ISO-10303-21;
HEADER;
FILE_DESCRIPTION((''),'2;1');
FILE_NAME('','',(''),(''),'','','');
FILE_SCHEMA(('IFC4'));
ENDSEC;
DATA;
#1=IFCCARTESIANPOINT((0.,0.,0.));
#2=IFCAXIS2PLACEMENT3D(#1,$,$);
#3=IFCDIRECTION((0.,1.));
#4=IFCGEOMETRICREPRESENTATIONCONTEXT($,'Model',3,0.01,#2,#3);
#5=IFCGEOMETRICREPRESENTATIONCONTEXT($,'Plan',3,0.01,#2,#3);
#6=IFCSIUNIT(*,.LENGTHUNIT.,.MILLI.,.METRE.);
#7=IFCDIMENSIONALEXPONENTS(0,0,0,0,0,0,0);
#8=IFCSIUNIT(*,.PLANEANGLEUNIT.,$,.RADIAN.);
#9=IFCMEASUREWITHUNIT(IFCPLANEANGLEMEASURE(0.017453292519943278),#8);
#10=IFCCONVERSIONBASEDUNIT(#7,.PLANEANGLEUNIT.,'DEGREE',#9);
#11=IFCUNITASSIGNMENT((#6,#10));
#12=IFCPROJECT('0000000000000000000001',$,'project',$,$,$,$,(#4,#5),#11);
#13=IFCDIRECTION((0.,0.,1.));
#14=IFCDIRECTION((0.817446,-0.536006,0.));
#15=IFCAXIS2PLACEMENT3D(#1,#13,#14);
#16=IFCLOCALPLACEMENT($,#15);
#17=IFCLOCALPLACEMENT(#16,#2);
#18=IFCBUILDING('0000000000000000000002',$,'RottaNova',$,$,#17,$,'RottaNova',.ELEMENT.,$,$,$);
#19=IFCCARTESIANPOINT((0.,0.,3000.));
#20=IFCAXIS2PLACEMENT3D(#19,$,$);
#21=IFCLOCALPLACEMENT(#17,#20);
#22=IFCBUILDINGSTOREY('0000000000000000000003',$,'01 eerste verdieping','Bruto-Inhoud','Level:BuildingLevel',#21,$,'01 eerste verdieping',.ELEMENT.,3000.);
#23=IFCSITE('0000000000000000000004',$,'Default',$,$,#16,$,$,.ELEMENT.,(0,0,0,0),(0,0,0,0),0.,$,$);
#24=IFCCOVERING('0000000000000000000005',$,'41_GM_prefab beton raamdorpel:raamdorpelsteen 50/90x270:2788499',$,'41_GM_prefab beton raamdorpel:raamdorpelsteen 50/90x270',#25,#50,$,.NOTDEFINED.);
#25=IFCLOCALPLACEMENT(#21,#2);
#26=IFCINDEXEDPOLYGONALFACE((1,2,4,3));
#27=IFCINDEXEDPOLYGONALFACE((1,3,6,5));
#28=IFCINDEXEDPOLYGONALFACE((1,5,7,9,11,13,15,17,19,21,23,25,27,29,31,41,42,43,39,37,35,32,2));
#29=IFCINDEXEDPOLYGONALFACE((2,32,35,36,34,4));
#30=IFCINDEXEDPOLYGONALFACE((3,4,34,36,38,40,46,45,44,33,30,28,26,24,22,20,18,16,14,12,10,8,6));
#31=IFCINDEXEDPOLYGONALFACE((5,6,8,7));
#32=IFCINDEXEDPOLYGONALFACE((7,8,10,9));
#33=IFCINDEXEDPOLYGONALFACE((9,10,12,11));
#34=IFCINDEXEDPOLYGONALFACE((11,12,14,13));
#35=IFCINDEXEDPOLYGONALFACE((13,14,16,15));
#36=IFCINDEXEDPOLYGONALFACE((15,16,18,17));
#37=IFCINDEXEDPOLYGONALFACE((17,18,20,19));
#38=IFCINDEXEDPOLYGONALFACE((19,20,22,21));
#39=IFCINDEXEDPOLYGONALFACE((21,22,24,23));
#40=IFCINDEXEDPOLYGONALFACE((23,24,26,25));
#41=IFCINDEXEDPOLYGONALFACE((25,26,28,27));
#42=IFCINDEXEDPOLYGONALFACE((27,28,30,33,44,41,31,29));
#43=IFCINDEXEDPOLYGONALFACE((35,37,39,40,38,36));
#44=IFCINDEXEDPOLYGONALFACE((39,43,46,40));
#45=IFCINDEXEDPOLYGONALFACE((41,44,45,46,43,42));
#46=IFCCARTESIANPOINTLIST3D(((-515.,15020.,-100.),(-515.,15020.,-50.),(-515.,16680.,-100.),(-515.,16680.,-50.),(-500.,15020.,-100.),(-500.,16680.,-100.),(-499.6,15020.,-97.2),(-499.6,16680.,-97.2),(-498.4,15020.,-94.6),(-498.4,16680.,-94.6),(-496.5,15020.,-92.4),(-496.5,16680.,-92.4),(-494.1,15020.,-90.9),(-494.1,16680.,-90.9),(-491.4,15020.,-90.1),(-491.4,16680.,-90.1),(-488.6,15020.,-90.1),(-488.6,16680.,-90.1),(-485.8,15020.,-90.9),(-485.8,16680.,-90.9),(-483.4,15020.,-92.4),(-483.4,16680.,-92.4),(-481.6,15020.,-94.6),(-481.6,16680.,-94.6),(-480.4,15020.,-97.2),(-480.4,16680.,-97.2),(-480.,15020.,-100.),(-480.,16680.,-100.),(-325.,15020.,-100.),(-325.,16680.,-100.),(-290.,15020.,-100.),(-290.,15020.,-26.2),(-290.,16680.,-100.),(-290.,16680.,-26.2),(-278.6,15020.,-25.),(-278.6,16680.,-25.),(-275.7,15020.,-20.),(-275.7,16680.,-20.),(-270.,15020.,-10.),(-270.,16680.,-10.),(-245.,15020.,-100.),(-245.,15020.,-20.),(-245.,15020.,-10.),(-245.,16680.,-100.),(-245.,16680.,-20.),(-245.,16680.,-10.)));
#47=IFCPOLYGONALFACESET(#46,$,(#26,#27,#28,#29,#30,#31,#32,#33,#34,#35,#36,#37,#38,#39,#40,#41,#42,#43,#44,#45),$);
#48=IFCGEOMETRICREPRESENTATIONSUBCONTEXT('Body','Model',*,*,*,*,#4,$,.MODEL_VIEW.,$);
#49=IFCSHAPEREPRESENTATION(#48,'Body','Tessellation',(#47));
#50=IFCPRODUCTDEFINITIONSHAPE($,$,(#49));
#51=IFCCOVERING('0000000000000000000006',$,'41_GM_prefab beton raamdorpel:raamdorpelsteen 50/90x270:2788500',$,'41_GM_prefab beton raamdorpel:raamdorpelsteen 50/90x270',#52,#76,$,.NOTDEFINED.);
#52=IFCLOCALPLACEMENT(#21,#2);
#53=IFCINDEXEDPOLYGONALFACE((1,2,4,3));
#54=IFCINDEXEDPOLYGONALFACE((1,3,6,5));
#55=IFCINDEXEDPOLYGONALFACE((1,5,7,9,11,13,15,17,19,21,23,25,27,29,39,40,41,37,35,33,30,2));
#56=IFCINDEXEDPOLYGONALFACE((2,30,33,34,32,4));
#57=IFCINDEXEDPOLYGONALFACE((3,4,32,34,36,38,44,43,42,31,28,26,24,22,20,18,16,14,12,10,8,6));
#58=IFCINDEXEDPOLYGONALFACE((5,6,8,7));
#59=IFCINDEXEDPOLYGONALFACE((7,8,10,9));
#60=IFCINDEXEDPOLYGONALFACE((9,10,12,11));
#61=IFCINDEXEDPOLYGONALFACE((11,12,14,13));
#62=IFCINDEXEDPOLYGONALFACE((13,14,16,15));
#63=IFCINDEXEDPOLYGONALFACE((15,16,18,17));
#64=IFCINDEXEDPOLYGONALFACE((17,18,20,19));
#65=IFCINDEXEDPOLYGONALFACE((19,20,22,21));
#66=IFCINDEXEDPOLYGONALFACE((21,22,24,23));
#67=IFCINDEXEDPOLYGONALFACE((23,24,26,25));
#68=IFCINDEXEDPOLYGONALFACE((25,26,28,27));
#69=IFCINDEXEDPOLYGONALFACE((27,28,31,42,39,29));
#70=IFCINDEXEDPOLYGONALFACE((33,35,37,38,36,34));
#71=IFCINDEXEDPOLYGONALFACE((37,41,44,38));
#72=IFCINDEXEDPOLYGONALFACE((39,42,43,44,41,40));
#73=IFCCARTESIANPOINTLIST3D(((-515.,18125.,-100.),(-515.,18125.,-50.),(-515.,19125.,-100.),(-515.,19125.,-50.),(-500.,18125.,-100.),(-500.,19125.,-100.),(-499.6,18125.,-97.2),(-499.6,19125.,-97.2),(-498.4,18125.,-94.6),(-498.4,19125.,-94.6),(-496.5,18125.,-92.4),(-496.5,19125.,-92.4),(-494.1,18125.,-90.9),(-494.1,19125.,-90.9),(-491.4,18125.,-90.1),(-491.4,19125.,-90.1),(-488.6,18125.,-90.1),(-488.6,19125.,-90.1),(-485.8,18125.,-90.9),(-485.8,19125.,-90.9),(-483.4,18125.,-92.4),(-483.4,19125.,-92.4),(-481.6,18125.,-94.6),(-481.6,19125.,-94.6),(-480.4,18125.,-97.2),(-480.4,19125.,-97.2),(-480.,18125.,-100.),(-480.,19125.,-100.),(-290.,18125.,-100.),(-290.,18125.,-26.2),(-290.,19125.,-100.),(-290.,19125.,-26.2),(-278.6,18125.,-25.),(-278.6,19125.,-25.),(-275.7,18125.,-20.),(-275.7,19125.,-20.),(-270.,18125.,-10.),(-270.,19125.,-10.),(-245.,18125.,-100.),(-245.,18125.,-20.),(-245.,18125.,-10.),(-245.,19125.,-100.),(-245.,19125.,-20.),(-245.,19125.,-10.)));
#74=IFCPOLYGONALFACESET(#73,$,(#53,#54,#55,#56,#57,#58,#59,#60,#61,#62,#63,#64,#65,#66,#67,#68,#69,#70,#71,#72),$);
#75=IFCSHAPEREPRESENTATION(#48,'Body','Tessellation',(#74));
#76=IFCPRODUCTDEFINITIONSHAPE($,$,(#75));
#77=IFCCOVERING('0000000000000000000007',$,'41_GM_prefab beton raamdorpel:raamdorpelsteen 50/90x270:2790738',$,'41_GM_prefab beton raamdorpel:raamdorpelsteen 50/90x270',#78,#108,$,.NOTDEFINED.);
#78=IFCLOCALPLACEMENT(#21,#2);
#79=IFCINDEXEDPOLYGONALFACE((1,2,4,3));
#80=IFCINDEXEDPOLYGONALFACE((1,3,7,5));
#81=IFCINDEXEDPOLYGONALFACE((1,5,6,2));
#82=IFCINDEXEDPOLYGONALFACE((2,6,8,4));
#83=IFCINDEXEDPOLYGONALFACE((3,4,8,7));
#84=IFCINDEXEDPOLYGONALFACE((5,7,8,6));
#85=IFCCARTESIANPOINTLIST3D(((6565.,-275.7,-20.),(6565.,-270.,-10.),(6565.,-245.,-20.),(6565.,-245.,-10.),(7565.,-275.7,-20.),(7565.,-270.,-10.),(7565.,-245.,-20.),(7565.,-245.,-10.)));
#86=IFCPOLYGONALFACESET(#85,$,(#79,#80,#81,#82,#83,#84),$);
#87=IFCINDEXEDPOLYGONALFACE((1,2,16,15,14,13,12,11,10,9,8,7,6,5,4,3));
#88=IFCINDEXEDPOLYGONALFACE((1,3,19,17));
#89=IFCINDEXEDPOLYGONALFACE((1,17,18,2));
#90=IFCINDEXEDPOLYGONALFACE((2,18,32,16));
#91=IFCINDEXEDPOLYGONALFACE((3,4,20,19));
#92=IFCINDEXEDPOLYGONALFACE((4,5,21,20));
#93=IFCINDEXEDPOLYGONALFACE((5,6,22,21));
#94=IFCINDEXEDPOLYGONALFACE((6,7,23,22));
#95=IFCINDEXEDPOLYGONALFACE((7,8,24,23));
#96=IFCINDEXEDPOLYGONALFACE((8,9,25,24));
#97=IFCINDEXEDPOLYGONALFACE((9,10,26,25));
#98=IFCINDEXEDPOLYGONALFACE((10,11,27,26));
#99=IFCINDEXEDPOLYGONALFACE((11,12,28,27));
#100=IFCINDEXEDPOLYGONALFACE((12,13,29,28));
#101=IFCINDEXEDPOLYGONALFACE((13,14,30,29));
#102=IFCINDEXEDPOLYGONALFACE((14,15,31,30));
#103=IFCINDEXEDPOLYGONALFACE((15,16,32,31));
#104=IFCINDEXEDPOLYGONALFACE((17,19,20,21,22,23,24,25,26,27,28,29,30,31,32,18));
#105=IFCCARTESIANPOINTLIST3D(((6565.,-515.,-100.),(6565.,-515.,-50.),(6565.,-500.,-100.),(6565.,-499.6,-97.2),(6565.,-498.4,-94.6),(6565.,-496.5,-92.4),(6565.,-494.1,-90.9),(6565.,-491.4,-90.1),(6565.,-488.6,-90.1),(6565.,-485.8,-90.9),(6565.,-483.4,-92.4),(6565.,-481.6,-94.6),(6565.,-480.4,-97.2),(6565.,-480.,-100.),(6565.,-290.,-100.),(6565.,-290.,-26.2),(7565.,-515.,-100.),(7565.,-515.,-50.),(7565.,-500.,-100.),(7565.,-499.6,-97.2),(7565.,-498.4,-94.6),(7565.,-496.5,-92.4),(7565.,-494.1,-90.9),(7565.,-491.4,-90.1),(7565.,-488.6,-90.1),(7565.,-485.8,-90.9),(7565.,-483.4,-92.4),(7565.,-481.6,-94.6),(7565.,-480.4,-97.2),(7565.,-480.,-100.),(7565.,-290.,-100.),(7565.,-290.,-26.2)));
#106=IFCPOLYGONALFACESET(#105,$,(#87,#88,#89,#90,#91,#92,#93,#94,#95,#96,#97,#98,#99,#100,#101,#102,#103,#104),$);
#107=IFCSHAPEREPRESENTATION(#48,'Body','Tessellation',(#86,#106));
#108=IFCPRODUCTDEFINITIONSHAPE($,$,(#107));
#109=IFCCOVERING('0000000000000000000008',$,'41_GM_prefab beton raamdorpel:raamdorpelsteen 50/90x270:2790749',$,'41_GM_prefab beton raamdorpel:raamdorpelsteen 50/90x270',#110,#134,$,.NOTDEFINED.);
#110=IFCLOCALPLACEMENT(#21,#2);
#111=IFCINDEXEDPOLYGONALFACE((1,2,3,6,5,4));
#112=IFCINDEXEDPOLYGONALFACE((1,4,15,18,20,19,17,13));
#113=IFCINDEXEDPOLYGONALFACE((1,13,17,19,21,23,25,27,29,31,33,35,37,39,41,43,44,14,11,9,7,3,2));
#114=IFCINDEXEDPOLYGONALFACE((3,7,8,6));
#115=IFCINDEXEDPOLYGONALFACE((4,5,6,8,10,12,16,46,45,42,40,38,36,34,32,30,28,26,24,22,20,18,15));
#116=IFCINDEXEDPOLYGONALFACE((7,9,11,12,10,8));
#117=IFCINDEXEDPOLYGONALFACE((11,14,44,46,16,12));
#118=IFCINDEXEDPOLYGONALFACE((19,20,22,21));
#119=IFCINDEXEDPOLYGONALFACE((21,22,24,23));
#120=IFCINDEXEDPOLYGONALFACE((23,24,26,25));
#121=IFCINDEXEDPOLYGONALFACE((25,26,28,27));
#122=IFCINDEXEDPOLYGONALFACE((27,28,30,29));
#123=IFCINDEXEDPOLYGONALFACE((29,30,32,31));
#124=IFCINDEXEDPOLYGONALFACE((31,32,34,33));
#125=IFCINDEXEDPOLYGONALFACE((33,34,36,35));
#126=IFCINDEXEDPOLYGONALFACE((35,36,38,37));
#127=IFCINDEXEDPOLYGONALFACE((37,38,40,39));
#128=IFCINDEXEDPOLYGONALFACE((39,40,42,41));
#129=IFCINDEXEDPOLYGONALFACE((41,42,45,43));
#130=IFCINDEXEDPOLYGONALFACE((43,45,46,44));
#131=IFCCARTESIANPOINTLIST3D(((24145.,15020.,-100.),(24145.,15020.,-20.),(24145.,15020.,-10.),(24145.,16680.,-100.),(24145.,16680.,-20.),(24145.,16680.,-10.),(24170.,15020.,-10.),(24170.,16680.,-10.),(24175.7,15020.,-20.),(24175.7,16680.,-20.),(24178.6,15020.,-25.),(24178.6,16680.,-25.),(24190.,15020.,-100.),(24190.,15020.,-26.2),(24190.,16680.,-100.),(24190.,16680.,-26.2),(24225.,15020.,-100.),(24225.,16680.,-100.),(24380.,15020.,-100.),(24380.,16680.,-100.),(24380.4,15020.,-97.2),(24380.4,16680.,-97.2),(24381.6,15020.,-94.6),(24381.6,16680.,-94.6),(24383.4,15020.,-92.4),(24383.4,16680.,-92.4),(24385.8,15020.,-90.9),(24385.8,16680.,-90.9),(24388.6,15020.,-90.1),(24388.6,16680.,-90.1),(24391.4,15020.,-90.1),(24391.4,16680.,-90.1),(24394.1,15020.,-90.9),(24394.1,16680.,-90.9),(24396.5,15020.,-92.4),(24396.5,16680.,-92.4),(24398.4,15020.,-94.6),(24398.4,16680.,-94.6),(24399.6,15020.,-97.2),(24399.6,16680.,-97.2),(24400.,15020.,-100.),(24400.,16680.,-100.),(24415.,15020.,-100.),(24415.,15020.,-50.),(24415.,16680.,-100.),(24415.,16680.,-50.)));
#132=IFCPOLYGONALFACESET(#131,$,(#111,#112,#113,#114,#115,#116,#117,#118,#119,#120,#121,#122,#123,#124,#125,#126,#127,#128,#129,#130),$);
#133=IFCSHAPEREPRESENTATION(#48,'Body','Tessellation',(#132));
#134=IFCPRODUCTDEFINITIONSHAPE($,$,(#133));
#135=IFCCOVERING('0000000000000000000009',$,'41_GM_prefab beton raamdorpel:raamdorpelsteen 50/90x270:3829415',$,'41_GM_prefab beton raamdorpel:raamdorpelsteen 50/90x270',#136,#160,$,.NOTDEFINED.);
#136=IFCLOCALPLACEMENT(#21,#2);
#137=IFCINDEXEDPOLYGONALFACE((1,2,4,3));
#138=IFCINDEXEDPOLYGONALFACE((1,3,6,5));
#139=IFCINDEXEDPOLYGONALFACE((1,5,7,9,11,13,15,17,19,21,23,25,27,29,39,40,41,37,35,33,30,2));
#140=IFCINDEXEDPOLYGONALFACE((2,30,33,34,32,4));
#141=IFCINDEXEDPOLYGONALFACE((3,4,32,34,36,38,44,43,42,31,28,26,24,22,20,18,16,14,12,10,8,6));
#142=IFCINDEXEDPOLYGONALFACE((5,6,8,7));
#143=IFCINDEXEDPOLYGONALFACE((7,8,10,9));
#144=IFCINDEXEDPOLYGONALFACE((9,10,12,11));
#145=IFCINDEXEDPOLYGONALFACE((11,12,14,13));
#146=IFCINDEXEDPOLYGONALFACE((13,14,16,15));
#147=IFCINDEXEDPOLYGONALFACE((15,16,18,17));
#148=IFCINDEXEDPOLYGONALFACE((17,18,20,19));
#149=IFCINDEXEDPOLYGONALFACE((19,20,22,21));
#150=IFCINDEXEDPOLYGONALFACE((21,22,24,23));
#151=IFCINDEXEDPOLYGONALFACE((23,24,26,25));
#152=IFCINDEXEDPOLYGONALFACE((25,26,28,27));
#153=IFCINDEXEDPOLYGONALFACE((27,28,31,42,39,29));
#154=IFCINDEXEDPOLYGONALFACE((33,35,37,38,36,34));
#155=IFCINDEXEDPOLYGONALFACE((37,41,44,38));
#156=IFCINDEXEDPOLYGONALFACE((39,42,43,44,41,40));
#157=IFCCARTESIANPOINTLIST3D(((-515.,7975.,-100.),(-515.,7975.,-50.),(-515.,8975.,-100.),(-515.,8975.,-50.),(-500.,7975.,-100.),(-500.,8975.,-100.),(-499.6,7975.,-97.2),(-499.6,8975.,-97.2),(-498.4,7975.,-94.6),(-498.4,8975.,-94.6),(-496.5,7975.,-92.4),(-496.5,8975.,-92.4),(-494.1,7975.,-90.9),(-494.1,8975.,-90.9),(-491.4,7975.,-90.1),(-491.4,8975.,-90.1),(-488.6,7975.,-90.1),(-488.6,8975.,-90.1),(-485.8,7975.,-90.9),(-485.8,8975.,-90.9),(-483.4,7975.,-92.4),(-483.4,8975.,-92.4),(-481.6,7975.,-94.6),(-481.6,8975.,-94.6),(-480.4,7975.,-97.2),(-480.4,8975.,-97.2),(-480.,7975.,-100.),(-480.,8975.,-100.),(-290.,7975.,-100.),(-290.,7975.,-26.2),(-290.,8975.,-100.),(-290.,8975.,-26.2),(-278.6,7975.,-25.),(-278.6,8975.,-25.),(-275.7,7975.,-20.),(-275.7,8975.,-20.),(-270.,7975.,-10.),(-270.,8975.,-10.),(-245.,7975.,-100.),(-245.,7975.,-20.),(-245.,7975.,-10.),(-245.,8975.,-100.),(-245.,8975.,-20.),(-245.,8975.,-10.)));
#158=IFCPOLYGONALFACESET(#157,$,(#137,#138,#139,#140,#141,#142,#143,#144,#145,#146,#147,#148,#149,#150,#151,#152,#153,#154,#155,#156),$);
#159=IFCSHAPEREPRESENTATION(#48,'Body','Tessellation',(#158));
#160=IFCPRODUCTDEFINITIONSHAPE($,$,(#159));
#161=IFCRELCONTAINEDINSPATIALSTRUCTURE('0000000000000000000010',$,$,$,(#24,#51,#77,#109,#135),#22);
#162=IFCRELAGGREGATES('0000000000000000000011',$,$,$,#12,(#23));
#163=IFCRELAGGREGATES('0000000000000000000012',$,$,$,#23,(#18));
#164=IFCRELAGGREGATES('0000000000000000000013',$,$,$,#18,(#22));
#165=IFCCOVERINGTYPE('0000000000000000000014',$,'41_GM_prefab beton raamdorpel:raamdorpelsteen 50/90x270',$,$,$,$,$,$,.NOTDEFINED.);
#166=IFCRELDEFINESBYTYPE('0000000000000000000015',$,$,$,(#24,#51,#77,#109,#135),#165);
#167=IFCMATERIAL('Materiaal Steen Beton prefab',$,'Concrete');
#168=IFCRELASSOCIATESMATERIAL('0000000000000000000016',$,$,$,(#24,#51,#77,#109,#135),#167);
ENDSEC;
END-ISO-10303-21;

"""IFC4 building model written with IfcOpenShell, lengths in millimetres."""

from ifc_helpers import new_model, entity, si_unit, converted_unit, direction, frame, origin, place, context, subcontext, project, spatial, line, arc, indexed_curve, outline, extrude, material, type_object, element, save


model = new_model("IFC4")

# Units and contexts
model_context = context("Model", 3, precision=0.01, world=origin(), true_north=direction((0.0, 1.0)))
plan_context = context("Plan", 3, precision=0.01, world=origin(), true_north=direction((0.0, 1.0)))
body_context = subcontext(model_context, "Body", "Model", "MODEL_VIEW")
ifc_project = project(units=[si_unit("LENGTHUNIT", "METRE", prefix="MILLI"), converted_unit("PLANEANGLEUNIT", "DEGREE", entity("IfcPlaneAngleMeasure", 0.017453292519943278), si_unit("PLANEANGLEUNIT", "RADIAN"), dimensions=[0, 0, 0, 0, 0, 0, 0])], contexts=[model_context, plan_context])

# Site, building, storey
site_placement = place(None, frame((0.0, 0.0, 0.0), z_axis=(0.0, 0.0, 1.0), x_axis=(0.817446, -0.536006, 0.0)))
site = spatial("IfcSite", under=ifc_project, at=site_placement, Name="Default", CompositionType="ELEMENT", RefLatitude=(0, 0, 0, 0), RefLongitude=(0, 0, 0, 0), RefElevation=0.0)
building_placement = place(site_placement, origin())
building = spatial("IfcBuilding", under=site, at=building_placement, Name="RottaNova", LongName="RottaNova", CompositionType="ELEMENT")
storey_placement = place(building_placement, frame((0.0, 0.0, 3000.0)))
storey = spatial("IfcBuildingStorey", under=building, at=storey_placement, Name="01 eerste verdieping", Description="Bruto-Inhoud", ObjectType="Level:BuildingLevel", LongName="01 eerste verdieping", CompositionType="ELEMENT", Elevation=3000.0)

# Coverings
ifc_material_1 = material(Name="Materiaal Steen Beton prefab", Category="Concrete")
covering_type_1 = type_object("IfcCoveringType", Name="41_GM_prefab beton raamdorpel:raamdorpelsteen 50/90x270", PredefinedType="NOTDEFINED")
covering_1_placement = place(storey_placement, origin())
element("IfcCovering", 1, at=covering_1_placement, inside=storey, type_object=covering_type_1, material=ifc_material_1, Name="41_GM_prefab beton raamdorpel:raamdorpelsteen 50/90x270:2788499", ObjectType="41_GM_prefab beton raamdorpel:raamdorpelsteen 50/90x270", PredefinedType="NOTDEFINED", context=body_context, shape_type="SweptSolid", body=[
    extrude(outline(indexed_curve([(74.2, -48.6), (99.2, -48.6), (99.2, -38.6), (99.2, 41.4), (54.2, 41.4), (19.2, 41.4), (-135.8, 41.4), (-145.8, 31.4), (-155.8, 41.4), (-170.8, 41.4), (-170.8, -8.6), (54.2, -32.4), (65.5, -33.6), (68.4, -38.6)], segments=[line(1, 2, 3, 4, 5, 6, 7), arc(7, 8, 9), line(9, 10, 11, 12, 13, 14, 1)], self_intersect=False)), frame((-344.2, 15020.0, -58.6), z_axis=(0.0, 1.0, 0.0), x_axis=(1.0, 0.0, 0.0)), (0.0, 0.0, 1.0), 1660.0),
])
covering_2_placement = place(storey_placement, origin())
element("IfcCovering", 2, at=covering_2_placement, inside=storey, type_object=covering_type_1, material=ifc_material_1, Name="41_GM_prefab beton raamdorpel:raamdorpelsteen 50/90x270:2788500", ObjectType="41_GM_prefab beton raamdorpel:raamdorpelsteen 50/90x270", PredefinedType="NOTDEFINED", context=body_context, shape_type="SweptSolid", body=[
    extrude(outline(indexed_curve([(75.8, -45.1), (100.8, -45.1), (100.8, -35.1), (100.8, 44.9), (55.8, 44.9), (-134.2, 44.9), (-144.2, 34.9), (-154.2, 44.9), (-169.2, 44.9), (-169.2, -5.1), (55.8, -28.9), (67.1, -30.1), (70.0, -35.1)], segments=[line(1, 2, 3, 4, 5, 6), arc(6, 7, 8), line(8, 9, 10, 11, 12, 13, 1)], self_intersect=False)), frame((-345.8, 18125.0, -55.1), z_axis=(0.0, 1.0, 0.0), x_axis=(1.0, 0.0, 0.0)), (0.0, 0.0, 1.0), 1000.0),
])
covering_3_placement = place(storey_placement, origin())
element("IfcCovering", 3, at=covering_3_placement, inside=storey, type_object=covering_type_1, material=ifc_material_1, Name="41_GM_prefab beton raamdorpel:raamdorpelsteen 50/90x270:2790738", ObjectType="41_GM_prefab beton raamdorpel:raamdorpelsteen 50/90x270", PredefinedType="NOTDEFINED", context=body_context, shape_type="SweptSolid", body=[
    extrude(outline(indexed_curve([(1.2, -12.1), (12.7, -12.1), (-2.6, 14.6), (-11.3, 9.6), (1.2, -12.1)], self_intersect=False)), frame((6565.0, -258.9, -15.0), z_axis=(1.0, 0.0, 0.0), x_axis=(0.0, -0.5, -0.866025)), (0.0, 0.0, 1.0), 1000.0),
    extrude(outline(indexed_curve([(-48.3, -20.6), (141.7, -20.6), (141.7, 53.2), (-83.3, 29.4), (-83.3, -20.6), (-68.3, -20.6), (-58.3, -10.6)], segments=[line(1, 2, 3, 4, 5, 6), arc(6, 7, 1)], self_intersect=False)), frame((6565.0, -431.7, -79.4), z_axis=(1.0, 0.0, 0.0), x_axis=(0.0, 1.0, 0.0)), (0.0, 0.0, 1.0), 1000.0),
])
covering_4_placement = place(storey_placement, origin())
element("IfcCovering", 4, at=covering_4_placement, inside=storey, type_object=covering_type_1, material=ifc_material_1, Name="41_GM_prefab beton raamdorpel:raamdorpelsteen 50/90x270:2790749", ObjectType="41_GM_prefab beton raamdorpel:raamdorpelsteen 50/90x270", PredefinedType="NOTDEFINED", context=body_context, shape_type="SweptSolid", body=[
    extrude(outline(indexed_curve([(-79.1, -40.0), (-91.6, -61.6), (-83.0, -66.6), (-13.7, -106.6), (8.8, -67.6), (26.3, -37.3), (103.8, 96.9), (100.1, 110.6), (113.8, 114.2), (121.3, 127.2), (78.0, 152.2), (-55.1, -30.7), (-61.8, -40.0), (-67.6, -40.0)], segments=[line(1, 2, 3, 4, 5, 6, 7), arc(7, 8, 9), line(9, 10, 11, 12, 13, 14, 1)], self_intersect=False)), frame((24244.2, 15020.0, -58.6), z_axis=(0.0, -1.0, 0.0), x_axis=(0.5, 0.0, -0.866025)), (0.0, 0.0, -1.0), 1660.0),
])
covering_5_placement = place(storey_placement, origin())
element("IfcCovering", 5, at=covering_5_placement, inside=storey, type_object=covering_type_1, material=ifc_material_1, Name="41_GM_prefab beton raamdorpel:raamdorpelsteen 50/90x270:3829415", ObjectType="41_GM_prefab beton raamdorpel:raamdorpelsteen 50/90x270", PredefinedType="NOTDEFINED", context=body_context, shape_type="SweptSolid", body=[
    extrude(outline(indexed_curve([(75.8, -45.1), (100.8, -45.1), (100.8, -35.1), (100.8, 44.9), (55.8, 44.9), (-134.2, 44.9), (-144.2, 34.9), (-154.2, 44.9), (-169.2, 44.9), (-169.2, -5.1), (55.8, -28.9), (67.1, -30.1), (70.0, -35.1)], segments=[line(1, 2, 3, 4, 5, 6), arc(6, 7, 8), line(8, 9, 10, 11, 12, 13, 1)], self_intersect=False)), frame((-345.8, 7975.0, -55.1), z_axis=(0.0, 1.0, 0.0), x_axis=(1.0, 0.0, 0.0)), (0.0, 0.0, 1.0), 1000.0),
])

save(model, "model.ifc")
